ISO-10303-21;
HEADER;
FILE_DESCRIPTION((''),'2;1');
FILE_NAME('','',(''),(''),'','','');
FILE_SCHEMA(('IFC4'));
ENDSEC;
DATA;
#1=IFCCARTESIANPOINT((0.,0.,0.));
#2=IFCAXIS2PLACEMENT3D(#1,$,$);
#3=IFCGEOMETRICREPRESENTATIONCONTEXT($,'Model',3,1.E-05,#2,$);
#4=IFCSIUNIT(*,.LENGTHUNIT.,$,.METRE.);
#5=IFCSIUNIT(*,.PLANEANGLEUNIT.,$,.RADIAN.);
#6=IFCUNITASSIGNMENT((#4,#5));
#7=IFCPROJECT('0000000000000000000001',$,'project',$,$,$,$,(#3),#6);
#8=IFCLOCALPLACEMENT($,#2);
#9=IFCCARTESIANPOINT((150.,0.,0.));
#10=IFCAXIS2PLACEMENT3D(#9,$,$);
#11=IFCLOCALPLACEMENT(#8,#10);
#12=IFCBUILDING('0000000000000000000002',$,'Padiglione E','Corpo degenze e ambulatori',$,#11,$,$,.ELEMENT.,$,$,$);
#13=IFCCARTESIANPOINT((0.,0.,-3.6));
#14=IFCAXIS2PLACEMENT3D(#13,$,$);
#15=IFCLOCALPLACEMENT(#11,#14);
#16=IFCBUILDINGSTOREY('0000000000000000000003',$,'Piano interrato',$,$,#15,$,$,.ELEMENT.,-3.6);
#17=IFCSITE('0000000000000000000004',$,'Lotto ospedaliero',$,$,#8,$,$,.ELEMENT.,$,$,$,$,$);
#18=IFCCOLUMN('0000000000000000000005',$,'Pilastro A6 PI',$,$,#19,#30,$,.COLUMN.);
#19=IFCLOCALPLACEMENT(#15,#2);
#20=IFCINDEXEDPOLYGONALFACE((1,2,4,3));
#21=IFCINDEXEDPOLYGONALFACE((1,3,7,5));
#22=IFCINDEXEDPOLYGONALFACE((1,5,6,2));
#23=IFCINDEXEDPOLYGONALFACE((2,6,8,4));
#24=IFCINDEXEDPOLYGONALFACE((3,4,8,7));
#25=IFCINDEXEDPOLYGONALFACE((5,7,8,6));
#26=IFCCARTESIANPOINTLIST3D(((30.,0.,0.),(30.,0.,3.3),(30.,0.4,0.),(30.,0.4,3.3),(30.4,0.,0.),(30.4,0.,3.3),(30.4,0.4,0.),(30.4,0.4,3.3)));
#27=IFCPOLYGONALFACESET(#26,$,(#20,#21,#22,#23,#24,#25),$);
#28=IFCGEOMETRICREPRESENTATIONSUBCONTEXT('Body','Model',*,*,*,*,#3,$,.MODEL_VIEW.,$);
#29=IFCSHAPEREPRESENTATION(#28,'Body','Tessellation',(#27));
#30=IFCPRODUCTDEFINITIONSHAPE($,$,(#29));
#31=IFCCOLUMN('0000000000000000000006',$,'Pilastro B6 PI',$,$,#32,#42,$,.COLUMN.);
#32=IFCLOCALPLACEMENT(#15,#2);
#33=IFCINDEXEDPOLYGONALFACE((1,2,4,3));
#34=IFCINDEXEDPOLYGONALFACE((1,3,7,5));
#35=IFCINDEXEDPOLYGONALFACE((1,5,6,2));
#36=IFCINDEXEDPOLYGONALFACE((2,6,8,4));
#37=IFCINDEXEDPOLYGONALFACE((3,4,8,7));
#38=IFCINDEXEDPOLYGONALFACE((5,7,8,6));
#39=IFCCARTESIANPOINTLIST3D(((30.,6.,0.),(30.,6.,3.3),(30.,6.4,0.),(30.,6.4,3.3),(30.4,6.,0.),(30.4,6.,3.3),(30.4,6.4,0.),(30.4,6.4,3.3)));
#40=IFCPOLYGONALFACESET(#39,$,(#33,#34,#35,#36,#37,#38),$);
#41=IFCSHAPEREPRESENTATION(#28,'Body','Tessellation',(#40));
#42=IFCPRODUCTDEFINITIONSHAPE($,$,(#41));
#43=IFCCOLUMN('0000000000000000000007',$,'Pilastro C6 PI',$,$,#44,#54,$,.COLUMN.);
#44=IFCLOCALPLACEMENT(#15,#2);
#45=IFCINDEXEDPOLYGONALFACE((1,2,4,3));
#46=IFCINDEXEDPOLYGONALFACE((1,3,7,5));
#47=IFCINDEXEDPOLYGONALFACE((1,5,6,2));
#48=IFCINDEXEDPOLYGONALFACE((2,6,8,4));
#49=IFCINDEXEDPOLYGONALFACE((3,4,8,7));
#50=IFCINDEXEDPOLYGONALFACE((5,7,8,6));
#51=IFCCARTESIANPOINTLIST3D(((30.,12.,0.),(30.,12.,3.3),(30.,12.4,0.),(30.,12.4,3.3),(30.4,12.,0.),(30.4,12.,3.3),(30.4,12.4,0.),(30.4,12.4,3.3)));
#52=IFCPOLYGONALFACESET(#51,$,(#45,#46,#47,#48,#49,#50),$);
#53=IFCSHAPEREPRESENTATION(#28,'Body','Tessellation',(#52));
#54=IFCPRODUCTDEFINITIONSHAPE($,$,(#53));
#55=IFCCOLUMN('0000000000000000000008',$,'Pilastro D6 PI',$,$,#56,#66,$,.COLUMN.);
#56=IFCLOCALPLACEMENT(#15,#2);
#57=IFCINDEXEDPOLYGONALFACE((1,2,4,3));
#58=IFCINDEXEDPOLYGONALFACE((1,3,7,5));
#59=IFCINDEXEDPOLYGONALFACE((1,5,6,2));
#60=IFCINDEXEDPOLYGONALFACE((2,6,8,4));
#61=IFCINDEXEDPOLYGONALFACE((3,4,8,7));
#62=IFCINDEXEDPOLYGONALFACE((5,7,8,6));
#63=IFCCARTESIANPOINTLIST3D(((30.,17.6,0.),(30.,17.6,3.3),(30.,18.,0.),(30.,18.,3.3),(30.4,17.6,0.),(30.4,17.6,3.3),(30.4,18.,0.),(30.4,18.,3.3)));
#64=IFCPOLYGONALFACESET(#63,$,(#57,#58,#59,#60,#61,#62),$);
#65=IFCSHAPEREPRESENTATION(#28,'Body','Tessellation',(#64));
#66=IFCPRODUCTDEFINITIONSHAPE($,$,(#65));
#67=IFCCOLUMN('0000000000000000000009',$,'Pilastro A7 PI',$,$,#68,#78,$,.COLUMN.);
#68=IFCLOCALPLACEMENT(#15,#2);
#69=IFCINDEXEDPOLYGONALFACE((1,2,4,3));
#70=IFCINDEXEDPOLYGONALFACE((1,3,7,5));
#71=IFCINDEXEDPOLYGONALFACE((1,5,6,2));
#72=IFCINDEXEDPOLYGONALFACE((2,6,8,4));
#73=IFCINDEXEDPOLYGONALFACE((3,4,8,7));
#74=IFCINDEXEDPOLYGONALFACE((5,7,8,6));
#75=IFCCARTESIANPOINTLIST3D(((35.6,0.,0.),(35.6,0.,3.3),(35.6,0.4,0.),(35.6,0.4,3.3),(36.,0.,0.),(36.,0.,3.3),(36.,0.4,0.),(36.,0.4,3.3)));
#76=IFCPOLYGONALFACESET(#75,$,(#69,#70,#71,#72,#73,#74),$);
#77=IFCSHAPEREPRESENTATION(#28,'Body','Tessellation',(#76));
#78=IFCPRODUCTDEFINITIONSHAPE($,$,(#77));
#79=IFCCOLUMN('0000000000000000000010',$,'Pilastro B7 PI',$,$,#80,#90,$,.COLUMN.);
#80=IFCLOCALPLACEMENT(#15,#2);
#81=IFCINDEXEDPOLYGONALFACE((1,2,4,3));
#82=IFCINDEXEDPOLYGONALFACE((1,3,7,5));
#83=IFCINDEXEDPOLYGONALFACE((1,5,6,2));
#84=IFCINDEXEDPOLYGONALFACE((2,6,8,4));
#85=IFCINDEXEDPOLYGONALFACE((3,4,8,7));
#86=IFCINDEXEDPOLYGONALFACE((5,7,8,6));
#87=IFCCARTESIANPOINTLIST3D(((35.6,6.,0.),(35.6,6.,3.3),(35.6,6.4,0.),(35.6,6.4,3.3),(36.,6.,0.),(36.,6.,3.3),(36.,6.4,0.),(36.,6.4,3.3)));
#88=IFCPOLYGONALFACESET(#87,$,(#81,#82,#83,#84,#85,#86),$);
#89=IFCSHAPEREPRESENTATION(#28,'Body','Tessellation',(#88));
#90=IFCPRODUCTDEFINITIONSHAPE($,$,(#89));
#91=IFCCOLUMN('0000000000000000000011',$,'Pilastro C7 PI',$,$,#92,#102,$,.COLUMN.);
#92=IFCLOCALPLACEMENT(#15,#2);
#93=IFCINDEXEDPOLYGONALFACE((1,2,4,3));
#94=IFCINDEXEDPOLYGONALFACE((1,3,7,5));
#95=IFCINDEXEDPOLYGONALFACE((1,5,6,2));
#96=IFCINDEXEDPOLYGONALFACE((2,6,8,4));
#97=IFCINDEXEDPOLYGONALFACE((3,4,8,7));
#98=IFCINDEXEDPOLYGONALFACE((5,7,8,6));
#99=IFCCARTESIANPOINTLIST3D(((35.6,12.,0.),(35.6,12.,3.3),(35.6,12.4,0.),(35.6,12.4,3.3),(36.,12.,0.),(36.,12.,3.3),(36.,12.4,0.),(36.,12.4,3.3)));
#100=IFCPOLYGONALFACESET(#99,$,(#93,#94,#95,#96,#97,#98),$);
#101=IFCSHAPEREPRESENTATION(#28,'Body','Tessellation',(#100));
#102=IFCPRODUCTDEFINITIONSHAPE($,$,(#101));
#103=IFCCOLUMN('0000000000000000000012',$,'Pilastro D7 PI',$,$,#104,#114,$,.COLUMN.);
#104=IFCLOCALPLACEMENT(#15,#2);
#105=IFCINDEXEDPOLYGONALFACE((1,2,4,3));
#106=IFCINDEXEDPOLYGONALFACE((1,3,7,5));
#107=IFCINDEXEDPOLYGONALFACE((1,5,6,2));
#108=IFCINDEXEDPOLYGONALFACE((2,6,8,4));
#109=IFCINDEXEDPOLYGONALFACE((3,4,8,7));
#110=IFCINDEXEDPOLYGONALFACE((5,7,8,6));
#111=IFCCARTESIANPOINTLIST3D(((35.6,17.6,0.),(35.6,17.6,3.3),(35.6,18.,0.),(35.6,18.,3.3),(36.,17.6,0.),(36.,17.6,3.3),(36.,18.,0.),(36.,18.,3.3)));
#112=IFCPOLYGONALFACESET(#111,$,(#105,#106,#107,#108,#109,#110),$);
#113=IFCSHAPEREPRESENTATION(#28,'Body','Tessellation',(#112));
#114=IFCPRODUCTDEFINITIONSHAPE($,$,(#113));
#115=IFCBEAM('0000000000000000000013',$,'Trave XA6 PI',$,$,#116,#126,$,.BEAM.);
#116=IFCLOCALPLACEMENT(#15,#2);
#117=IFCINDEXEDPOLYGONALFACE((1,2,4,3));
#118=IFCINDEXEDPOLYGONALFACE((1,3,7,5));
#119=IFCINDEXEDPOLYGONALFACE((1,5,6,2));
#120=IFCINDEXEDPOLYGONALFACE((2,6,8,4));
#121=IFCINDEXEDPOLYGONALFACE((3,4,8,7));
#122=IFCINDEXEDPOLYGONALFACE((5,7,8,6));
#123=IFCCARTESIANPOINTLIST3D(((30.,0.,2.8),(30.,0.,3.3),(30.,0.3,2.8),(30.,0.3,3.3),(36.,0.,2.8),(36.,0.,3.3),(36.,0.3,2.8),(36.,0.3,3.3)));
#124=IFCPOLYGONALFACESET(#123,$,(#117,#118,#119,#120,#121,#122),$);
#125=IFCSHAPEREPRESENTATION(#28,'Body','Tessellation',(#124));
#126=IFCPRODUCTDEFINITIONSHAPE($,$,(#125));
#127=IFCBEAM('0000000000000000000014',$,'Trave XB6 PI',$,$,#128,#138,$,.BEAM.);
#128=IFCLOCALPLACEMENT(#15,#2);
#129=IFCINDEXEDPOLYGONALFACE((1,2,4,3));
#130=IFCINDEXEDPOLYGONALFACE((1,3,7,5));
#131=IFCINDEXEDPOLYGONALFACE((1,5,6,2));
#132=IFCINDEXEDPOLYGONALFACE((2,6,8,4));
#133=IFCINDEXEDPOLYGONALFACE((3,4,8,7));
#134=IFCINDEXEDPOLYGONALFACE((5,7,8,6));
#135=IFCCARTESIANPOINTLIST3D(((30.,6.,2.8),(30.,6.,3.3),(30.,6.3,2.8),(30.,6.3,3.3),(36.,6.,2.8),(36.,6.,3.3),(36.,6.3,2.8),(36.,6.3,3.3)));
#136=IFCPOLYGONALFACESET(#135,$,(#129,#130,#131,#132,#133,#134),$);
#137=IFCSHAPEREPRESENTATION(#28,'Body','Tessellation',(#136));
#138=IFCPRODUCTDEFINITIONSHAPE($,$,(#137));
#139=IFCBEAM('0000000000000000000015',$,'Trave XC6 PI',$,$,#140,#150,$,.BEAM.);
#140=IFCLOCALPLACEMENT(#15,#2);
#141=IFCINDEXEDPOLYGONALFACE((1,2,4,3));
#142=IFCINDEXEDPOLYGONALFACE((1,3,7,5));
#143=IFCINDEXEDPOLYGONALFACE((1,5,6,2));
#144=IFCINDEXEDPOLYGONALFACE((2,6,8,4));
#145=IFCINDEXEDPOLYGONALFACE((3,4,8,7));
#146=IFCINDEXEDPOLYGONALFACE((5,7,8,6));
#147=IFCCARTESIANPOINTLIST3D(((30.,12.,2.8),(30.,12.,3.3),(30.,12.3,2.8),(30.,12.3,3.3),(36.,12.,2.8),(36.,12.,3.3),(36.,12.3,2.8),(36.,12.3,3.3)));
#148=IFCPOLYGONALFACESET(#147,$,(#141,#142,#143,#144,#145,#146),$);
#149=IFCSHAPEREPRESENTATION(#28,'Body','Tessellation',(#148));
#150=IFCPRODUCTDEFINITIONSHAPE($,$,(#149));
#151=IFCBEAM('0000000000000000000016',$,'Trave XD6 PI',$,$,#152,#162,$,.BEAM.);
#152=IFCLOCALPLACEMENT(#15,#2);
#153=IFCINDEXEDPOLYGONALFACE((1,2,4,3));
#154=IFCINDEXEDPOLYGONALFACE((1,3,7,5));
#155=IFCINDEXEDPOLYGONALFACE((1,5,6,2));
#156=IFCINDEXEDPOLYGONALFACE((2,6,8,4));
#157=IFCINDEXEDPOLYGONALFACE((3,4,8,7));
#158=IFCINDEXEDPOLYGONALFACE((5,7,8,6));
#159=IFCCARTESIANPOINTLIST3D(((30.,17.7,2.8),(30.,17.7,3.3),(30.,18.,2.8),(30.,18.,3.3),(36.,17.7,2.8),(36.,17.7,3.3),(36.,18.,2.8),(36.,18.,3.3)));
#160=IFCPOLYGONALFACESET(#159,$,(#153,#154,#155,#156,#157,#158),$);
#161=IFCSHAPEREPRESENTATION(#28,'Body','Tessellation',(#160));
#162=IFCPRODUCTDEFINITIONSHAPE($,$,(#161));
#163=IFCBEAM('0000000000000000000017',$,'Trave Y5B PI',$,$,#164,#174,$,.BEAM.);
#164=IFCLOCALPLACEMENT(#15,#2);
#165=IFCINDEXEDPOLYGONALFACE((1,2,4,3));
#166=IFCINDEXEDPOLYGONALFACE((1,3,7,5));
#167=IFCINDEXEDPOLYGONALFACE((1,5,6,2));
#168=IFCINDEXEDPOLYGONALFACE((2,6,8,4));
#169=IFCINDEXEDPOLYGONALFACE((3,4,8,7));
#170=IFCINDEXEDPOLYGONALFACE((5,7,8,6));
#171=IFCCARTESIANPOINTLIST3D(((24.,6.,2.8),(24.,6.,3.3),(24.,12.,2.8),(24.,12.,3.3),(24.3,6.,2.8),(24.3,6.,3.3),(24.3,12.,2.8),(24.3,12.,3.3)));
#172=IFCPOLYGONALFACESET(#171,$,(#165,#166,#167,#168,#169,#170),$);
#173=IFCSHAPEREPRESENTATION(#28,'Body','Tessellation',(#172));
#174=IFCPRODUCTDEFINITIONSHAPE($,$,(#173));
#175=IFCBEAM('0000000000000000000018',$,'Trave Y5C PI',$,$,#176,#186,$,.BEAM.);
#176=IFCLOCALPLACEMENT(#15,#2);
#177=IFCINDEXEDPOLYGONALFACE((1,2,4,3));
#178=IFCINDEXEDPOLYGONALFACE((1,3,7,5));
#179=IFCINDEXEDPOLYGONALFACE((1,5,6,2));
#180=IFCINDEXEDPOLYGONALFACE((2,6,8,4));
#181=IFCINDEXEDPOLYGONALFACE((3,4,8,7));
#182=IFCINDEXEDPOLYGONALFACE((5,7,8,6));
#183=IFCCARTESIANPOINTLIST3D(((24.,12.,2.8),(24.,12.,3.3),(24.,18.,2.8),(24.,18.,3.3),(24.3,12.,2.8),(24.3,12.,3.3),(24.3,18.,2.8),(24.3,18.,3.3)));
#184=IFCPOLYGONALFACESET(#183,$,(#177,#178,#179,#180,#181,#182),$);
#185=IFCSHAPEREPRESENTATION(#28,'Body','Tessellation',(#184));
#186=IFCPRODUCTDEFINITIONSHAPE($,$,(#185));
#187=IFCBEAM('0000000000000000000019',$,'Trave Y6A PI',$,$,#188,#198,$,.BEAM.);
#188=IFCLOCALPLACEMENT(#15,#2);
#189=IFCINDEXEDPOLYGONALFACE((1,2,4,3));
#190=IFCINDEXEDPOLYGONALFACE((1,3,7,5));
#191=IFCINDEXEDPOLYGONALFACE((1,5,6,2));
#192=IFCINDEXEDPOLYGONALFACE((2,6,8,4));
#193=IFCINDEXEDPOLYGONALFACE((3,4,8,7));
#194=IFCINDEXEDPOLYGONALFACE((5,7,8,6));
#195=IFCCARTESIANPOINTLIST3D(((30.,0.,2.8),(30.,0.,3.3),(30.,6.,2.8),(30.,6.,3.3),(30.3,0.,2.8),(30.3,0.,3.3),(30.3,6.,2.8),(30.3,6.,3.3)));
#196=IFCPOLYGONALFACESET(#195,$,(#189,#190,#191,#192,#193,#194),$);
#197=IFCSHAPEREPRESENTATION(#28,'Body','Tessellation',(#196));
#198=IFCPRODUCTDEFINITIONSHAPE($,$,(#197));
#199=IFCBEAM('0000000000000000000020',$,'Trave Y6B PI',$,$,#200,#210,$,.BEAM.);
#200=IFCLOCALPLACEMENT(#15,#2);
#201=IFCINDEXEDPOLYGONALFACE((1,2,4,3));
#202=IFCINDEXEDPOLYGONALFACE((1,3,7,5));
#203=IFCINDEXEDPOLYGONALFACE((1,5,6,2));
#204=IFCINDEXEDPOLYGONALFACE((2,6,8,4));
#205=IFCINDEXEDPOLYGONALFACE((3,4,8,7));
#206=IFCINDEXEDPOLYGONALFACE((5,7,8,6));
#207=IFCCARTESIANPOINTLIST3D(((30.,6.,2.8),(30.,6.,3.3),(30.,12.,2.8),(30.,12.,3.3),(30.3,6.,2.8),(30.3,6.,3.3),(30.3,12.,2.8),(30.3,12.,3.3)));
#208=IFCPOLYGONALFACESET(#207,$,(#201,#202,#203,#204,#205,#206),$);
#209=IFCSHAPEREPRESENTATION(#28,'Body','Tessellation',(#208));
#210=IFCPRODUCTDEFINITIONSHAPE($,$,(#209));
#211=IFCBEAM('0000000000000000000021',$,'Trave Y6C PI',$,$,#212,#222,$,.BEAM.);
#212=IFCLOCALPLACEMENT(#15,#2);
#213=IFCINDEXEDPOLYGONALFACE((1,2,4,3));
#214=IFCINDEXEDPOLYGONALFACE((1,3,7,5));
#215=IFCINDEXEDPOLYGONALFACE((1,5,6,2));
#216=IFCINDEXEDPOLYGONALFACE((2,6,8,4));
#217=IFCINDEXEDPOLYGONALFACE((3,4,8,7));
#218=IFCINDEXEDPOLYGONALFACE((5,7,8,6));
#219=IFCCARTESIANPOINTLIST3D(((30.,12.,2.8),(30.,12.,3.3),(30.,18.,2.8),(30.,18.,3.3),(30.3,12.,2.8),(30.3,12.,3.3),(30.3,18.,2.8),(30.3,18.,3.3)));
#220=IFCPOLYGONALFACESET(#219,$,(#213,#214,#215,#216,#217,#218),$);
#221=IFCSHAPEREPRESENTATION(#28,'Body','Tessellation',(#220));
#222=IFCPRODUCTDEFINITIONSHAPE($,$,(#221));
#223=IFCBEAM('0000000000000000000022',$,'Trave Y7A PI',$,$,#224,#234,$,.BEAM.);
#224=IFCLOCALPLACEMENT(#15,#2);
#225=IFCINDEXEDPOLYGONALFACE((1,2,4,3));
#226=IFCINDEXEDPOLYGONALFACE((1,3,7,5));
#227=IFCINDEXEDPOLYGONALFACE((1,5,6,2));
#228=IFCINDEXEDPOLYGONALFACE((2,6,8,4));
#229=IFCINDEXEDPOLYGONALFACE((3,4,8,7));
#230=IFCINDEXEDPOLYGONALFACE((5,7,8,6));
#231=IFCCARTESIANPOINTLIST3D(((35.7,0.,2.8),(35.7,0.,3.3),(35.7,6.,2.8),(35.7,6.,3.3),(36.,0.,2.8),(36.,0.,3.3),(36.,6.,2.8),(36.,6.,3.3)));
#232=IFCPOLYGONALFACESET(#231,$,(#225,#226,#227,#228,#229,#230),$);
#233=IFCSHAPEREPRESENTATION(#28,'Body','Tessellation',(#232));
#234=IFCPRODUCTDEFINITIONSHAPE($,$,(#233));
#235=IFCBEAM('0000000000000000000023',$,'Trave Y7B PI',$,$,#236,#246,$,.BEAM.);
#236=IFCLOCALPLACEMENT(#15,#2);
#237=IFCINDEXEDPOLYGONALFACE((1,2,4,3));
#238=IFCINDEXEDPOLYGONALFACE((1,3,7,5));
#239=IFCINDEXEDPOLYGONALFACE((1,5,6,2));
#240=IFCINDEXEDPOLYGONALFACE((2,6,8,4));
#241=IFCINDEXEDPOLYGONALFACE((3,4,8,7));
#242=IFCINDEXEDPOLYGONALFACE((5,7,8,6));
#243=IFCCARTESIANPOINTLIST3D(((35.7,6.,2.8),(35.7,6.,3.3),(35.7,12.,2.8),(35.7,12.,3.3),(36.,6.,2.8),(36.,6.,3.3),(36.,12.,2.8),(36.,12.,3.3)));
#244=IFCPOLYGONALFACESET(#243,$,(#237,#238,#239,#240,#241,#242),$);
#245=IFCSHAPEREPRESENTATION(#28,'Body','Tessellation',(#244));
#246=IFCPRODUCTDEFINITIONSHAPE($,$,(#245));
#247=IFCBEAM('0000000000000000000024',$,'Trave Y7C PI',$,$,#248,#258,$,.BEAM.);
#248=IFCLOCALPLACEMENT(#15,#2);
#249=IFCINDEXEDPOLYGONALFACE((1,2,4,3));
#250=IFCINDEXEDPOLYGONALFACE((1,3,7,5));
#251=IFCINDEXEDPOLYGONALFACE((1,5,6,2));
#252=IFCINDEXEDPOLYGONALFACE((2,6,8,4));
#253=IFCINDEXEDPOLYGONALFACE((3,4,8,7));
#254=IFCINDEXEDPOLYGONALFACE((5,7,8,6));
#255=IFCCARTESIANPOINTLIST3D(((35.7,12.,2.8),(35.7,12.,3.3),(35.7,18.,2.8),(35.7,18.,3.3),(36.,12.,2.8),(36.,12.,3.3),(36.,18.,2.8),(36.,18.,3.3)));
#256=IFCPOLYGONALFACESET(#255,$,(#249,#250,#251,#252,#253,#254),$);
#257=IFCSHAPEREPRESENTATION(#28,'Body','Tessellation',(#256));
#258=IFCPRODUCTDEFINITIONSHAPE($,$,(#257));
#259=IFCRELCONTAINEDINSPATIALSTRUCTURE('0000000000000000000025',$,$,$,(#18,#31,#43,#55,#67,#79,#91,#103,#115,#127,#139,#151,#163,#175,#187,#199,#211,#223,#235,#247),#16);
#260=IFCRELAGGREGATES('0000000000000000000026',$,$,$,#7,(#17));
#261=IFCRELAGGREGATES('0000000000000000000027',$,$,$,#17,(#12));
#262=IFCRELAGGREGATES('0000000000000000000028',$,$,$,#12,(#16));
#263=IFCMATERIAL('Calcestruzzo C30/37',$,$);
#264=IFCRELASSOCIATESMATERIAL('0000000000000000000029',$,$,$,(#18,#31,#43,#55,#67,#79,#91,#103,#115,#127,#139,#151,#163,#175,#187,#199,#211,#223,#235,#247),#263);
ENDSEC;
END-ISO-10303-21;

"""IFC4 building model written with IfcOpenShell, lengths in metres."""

from ifc_helpers import new_model, si_unit, frame, frame_2d, origin, place, context, subcontext, project, spatial, rectangle, extrude, material, element, save


model = new_model("IFC4")

# Units and contexts
model_context = context("Model", 3, precision=1e-05, world=origin())
body_context = subcontext(model_context, "Body", "Model", "MODEL_VIEW")
ifc_project = project(units=[si_unit("LENGTHUNIT", "METRE"), si_unit("PLANEANGLEUNIT", "RADIAN")], contexts=[model_context])

# Site, building, storey
site_placement = place(None, origin())
site = spatial("IfcSite", under=ifc_project, at=site_placement, Name="Lotto ospedaliero", CompositionType="ELEMENT")
building_placement = place(site_placement, frame((150.0, 0.0, 0.0)))
building = spatial("IfcBuilding", under=site, at=building_placement, Name="Padiglione E", Description="Corpo degenze e ambulatori", CompositionType="ELEMENT")
storey_placement = place(building_placement, frame((0.0, 0.0, -3.6)))
storey = spatial("IfcBuildingStorey", under=building, at=storey_placement, Name="Piano interrato", CompositionType="ELEMENT", Elevation=-3.6)

# Columns
ifc_material_1 = material(Name="Calcestruzzo C30/37")
for number, where, name in (
    (1, (30.0, 0.0, 0.0), "Pilastro A6 PI"),
    (2, (30.0, 6.0, 0.0), "Pilastro B6 PI"),
    (3, (30.0, 12.0, 0.0), "Pilastro C6 PI"),
    (4, (30.0, 17.6, 0.0), "Pilastro D6 PI"),
    (5, (35.6, 0.0, 0.0), "Pilastro A7 PI"),
    (6, (35.6, 6.0, 0.0), "Pilastro B7 PI"),
    (7, (35.6, 12.0, 0.0), "Pilastro C7 PI"),
    (8, (35.6, 17.6, 0.0), "Pilastro D7 PI"),
):
    element("IfcColumn", number, at=place(storey_placement, frame(where)), inside=storey, material=ifc_material_1, Name=name, PredefinedType="COLUMN", context=body_context, shape_type="SweptSolid", body=[
        extrude(rectangle(XDim=0.4, YDim=0.4, at=frame_2d((0.2, 0.2))), origin(), (0.0, 0.0, 1.0), 3.3),
    ])

# Beams
for number, where, name in (
    (9, (30.0, 0.0, 2.8), "Trave XA6 PI"),
    (10, (30.0, 6.0, 2.8), "Trave XB6 PI"),
    (11, (30.0, 12.0, 2.8), "Trave XC6 PI"),
    (12, (30.0, 17.7, 2.8), "Trave XD6 PI"),
):
    element("IfcBeam", number, at=place(storey_placement, frame(where)), inside=storey, material=ifc_material_1, Name=name, PredefinedType="BEAM", context=body_context, shape_type="SweptSolid", body=[
        extrude(rectangle(XDim=6.0, YDim=0.3, at=frame_2d((3.0, 0.15))), origin(), (0.0, 0.0, 1.0), 0.5),
    ])
for number, where, name in (
    (13, (24.0, 6.0, 2.8), "Trave Y5B PI"),
    (14, (24.0, 12.0, 2.8), "Trave Y5C PI"),
    (15, (30.0, 0.0, 2.8), "Trave Y6A PI"),
    (16, (30.0, 6.0, 2.8), "Trave Y6B PI"),
    (17, (30.0, 12.0, 2.8), "Trave Y6C PI"),
    (18, (35.7, 0.0, 2.8), "Trave Y7A PI"),
    (19, (35.7, 6.0, 2.8), "Trave Y7B PI"),
    (20, (35.7, 12.0, 2.8), "Trave Y7C PI"),
):
    element("IfcBeam", number, at=place(storey_placement, frame(where)), inside=storey, material=ifc_material_1, Name=name, PredefinedType="BEAM", context=body_context, shape_type="SweptSolid", body=[
        extrude(rectangle(XDim=0.3, YDim=6.0, at=frame_2d((0.15, 3.0))), origin(), (0.0, 0.0, 1.0), 0.5),
    ])

save(model, "model.ifc")
